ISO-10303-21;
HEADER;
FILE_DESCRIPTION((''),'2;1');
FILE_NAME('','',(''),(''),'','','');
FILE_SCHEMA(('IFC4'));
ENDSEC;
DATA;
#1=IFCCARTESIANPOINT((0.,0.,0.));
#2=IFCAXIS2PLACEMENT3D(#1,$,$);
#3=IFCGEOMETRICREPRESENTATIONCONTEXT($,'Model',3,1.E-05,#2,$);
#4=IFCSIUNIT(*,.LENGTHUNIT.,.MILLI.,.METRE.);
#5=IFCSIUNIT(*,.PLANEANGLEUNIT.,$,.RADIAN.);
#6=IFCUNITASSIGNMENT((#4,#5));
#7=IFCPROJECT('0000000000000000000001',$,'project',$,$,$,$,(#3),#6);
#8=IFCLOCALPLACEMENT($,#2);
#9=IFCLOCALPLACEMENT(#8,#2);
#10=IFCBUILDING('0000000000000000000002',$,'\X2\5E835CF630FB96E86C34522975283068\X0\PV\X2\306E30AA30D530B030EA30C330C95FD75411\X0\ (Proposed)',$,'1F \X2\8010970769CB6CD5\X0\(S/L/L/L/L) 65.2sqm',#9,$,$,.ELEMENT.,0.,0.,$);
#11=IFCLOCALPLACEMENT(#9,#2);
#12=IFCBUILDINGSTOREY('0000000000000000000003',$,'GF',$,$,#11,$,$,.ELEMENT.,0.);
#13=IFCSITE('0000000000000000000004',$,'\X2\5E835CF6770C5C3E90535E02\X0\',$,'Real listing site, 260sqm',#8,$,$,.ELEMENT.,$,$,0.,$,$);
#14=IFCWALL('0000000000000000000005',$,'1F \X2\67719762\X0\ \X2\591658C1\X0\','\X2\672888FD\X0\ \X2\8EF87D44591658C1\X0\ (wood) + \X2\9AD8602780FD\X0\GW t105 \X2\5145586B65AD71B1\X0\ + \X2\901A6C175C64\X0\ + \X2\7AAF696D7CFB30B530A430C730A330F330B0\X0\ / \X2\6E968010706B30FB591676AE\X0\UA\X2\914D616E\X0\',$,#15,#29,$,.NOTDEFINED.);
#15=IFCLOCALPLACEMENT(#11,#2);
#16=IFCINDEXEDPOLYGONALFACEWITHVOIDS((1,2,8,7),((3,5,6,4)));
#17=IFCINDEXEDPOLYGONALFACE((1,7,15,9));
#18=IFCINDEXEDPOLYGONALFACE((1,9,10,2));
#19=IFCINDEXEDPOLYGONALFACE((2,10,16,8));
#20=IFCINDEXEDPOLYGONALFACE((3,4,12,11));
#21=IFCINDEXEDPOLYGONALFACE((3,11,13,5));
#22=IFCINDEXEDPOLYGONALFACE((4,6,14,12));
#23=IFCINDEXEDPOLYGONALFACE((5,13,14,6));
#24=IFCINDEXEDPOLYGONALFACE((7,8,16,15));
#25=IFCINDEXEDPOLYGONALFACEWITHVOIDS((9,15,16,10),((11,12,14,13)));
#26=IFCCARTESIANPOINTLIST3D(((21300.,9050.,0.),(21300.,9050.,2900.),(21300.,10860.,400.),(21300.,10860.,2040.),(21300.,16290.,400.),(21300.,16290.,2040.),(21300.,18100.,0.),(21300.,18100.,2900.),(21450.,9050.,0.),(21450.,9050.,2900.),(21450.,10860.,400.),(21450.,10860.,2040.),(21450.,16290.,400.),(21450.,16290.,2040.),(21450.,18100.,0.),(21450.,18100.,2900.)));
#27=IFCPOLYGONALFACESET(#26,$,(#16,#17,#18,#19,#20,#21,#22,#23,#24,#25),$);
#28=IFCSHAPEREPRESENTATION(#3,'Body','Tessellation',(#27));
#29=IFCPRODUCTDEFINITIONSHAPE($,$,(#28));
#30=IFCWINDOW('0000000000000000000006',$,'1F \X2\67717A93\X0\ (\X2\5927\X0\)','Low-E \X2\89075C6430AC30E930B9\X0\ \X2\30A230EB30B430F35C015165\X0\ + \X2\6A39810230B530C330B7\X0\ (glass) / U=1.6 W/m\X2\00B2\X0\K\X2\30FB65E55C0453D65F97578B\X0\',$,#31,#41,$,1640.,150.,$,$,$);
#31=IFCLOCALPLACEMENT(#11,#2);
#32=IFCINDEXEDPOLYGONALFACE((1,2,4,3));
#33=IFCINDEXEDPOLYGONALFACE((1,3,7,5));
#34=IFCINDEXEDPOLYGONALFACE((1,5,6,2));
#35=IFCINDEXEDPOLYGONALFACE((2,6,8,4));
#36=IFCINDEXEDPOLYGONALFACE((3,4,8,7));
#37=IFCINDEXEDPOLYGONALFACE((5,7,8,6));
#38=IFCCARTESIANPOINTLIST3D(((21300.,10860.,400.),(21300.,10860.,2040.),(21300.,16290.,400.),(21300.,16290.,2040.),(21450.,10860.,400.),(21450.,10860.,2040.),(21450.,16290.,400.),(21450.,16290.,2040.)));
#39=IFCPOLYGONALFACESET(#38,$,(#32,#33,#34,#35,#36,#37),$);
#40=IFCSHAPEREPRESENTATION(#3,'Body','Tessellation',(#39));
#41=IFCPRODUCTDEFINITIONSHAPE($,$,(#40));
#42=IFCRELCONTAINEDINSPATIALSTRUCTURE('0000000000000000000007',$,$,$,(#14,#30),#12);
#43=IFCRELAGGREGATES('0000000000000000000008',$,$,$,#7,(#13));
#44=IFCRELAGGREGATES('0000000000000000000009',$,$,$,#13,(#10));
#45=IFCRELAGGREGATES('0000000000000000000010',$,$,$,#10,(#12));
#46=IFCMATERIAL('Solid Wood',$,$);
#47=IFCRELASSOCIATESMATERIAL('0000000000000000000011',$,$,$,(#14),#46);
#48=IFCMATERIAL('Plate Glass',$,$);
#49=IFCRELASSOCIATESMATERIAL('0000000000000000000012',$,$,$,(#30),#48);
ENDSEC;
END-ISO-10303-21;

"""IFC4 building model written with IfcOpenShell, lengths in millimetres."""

from ifc_helpers import new_model, si_unit, frame, frame_2d, origin, place, context, project, spatial, rectangle, extrude, material, element, fill, save


model = new_model("IFC4")

# Units and contexts
model_context = context("Model", 3, precision=1e-05, world=origin())
ifc_project = project(units=[si_unit("LENGTHUNIT", "METRE", prefix="MILLI"), si_unit("PLANEANGLEUNIT", "RADIAN")], contexts=[model_context])

# Site, building, storey
site_placement = place(None, origin())
site = spatial("IfcSite", under=ifc_project, at=site_placement, Name="広島県尾道市", ObjectType="Real listing site, 260sqm", CompositionType="ELEMENT", RefElevation=0.0)
building_placement = place(site_placement, origin())
building = spatial("IfcBuilding", under=site, at=building_placement, Name="広島・雨水利用とPVのオフグリッド志向 (Proposed)", ObjectType="1F 耐震構法(S/L/L/L/L) 65.2sqm", CompositionType="ELEMENT", ElevationOfRefHeight=0.0, ElevationOfTerrain=0.0)
storey_placement = place(building_placement, origin())
storey = spatial("IfcBuildingStorey", under=building, at=storey_placement, Name="GF", CompositionType="ELEMENT", Elevation=0.0)

# Shared definitions
ifc_material_1 = material(Name="Solid Wood")

# Wall, opening, window
wall_1_placement = place(storey_placement, frame((10650.0, 4525.0, 0.0)))
wall_1 = element("IfcWall", 1, at=wall_1_placement, inside=storey, material=ifc_material_1, Name="1F 東面 外壁", Description="木製 軸組外壁 (wood) + 高性能GW t105 充填断熱 + 通気層 + 窯業系サイディング / 準耐火・外皮UA配慮", PredefinedType="NOTDEFINED", context=model_context, shape_type="SweptSolid", body=[
    extrude(rectangle(XDim=150.0, YDim=9050.0, at=frame_2d((75.0, 4525.0))), frame((10650.0, 4525.0, 0.0)), (0.0, 0.0, 1.0), 2900.0),
])
opening_placement = place(storey_placement, frame((10650.0, 5430.0, 200.0)))
opening = element("IfcOpeningElement", 2, at=opening_placement, cuts=wall_1, PredefinedType="NOTDEFINED", context=model_context, shape_type="SweptSolid", body=[
    extrude(rectangle(XDim=150.0, YDim=5430.0, at=frame_2d((75.0, 2715.0))), frame((10650.0, 5430.0, 200.0)), (0.0, 0.0, 1.0), 1640.0),
])
ifc_material_2 = material(Name="Plate Glass")
window_placement = place(storey_placement, frame((10650.0, 5430.0, 200.0)))
window = element("IfcWindow", 3, at=window_placement, inside=storey, material=ifc_material_2, Name="1F 東窓 (大)", Description="Low-E 複層ガラス アルゴン封入 + 樹脂サッシ (glass) / U=1.6 W/m²K・日射取得型", OverallHeight=1640.0, OverallWidth=150.0, context=model_context, shape_type="SweptSolid", body=[
    extrude(rectangle(XDim=150.0, YDim=5430.0, at=frame_2d((75.0, 2715.0))), frame((10650.0, 5430.0, 200.0)), (0.0, 0.0, 1.0), 1640.0),
])
fill(opening, window)

save(model, "model.ifc")
